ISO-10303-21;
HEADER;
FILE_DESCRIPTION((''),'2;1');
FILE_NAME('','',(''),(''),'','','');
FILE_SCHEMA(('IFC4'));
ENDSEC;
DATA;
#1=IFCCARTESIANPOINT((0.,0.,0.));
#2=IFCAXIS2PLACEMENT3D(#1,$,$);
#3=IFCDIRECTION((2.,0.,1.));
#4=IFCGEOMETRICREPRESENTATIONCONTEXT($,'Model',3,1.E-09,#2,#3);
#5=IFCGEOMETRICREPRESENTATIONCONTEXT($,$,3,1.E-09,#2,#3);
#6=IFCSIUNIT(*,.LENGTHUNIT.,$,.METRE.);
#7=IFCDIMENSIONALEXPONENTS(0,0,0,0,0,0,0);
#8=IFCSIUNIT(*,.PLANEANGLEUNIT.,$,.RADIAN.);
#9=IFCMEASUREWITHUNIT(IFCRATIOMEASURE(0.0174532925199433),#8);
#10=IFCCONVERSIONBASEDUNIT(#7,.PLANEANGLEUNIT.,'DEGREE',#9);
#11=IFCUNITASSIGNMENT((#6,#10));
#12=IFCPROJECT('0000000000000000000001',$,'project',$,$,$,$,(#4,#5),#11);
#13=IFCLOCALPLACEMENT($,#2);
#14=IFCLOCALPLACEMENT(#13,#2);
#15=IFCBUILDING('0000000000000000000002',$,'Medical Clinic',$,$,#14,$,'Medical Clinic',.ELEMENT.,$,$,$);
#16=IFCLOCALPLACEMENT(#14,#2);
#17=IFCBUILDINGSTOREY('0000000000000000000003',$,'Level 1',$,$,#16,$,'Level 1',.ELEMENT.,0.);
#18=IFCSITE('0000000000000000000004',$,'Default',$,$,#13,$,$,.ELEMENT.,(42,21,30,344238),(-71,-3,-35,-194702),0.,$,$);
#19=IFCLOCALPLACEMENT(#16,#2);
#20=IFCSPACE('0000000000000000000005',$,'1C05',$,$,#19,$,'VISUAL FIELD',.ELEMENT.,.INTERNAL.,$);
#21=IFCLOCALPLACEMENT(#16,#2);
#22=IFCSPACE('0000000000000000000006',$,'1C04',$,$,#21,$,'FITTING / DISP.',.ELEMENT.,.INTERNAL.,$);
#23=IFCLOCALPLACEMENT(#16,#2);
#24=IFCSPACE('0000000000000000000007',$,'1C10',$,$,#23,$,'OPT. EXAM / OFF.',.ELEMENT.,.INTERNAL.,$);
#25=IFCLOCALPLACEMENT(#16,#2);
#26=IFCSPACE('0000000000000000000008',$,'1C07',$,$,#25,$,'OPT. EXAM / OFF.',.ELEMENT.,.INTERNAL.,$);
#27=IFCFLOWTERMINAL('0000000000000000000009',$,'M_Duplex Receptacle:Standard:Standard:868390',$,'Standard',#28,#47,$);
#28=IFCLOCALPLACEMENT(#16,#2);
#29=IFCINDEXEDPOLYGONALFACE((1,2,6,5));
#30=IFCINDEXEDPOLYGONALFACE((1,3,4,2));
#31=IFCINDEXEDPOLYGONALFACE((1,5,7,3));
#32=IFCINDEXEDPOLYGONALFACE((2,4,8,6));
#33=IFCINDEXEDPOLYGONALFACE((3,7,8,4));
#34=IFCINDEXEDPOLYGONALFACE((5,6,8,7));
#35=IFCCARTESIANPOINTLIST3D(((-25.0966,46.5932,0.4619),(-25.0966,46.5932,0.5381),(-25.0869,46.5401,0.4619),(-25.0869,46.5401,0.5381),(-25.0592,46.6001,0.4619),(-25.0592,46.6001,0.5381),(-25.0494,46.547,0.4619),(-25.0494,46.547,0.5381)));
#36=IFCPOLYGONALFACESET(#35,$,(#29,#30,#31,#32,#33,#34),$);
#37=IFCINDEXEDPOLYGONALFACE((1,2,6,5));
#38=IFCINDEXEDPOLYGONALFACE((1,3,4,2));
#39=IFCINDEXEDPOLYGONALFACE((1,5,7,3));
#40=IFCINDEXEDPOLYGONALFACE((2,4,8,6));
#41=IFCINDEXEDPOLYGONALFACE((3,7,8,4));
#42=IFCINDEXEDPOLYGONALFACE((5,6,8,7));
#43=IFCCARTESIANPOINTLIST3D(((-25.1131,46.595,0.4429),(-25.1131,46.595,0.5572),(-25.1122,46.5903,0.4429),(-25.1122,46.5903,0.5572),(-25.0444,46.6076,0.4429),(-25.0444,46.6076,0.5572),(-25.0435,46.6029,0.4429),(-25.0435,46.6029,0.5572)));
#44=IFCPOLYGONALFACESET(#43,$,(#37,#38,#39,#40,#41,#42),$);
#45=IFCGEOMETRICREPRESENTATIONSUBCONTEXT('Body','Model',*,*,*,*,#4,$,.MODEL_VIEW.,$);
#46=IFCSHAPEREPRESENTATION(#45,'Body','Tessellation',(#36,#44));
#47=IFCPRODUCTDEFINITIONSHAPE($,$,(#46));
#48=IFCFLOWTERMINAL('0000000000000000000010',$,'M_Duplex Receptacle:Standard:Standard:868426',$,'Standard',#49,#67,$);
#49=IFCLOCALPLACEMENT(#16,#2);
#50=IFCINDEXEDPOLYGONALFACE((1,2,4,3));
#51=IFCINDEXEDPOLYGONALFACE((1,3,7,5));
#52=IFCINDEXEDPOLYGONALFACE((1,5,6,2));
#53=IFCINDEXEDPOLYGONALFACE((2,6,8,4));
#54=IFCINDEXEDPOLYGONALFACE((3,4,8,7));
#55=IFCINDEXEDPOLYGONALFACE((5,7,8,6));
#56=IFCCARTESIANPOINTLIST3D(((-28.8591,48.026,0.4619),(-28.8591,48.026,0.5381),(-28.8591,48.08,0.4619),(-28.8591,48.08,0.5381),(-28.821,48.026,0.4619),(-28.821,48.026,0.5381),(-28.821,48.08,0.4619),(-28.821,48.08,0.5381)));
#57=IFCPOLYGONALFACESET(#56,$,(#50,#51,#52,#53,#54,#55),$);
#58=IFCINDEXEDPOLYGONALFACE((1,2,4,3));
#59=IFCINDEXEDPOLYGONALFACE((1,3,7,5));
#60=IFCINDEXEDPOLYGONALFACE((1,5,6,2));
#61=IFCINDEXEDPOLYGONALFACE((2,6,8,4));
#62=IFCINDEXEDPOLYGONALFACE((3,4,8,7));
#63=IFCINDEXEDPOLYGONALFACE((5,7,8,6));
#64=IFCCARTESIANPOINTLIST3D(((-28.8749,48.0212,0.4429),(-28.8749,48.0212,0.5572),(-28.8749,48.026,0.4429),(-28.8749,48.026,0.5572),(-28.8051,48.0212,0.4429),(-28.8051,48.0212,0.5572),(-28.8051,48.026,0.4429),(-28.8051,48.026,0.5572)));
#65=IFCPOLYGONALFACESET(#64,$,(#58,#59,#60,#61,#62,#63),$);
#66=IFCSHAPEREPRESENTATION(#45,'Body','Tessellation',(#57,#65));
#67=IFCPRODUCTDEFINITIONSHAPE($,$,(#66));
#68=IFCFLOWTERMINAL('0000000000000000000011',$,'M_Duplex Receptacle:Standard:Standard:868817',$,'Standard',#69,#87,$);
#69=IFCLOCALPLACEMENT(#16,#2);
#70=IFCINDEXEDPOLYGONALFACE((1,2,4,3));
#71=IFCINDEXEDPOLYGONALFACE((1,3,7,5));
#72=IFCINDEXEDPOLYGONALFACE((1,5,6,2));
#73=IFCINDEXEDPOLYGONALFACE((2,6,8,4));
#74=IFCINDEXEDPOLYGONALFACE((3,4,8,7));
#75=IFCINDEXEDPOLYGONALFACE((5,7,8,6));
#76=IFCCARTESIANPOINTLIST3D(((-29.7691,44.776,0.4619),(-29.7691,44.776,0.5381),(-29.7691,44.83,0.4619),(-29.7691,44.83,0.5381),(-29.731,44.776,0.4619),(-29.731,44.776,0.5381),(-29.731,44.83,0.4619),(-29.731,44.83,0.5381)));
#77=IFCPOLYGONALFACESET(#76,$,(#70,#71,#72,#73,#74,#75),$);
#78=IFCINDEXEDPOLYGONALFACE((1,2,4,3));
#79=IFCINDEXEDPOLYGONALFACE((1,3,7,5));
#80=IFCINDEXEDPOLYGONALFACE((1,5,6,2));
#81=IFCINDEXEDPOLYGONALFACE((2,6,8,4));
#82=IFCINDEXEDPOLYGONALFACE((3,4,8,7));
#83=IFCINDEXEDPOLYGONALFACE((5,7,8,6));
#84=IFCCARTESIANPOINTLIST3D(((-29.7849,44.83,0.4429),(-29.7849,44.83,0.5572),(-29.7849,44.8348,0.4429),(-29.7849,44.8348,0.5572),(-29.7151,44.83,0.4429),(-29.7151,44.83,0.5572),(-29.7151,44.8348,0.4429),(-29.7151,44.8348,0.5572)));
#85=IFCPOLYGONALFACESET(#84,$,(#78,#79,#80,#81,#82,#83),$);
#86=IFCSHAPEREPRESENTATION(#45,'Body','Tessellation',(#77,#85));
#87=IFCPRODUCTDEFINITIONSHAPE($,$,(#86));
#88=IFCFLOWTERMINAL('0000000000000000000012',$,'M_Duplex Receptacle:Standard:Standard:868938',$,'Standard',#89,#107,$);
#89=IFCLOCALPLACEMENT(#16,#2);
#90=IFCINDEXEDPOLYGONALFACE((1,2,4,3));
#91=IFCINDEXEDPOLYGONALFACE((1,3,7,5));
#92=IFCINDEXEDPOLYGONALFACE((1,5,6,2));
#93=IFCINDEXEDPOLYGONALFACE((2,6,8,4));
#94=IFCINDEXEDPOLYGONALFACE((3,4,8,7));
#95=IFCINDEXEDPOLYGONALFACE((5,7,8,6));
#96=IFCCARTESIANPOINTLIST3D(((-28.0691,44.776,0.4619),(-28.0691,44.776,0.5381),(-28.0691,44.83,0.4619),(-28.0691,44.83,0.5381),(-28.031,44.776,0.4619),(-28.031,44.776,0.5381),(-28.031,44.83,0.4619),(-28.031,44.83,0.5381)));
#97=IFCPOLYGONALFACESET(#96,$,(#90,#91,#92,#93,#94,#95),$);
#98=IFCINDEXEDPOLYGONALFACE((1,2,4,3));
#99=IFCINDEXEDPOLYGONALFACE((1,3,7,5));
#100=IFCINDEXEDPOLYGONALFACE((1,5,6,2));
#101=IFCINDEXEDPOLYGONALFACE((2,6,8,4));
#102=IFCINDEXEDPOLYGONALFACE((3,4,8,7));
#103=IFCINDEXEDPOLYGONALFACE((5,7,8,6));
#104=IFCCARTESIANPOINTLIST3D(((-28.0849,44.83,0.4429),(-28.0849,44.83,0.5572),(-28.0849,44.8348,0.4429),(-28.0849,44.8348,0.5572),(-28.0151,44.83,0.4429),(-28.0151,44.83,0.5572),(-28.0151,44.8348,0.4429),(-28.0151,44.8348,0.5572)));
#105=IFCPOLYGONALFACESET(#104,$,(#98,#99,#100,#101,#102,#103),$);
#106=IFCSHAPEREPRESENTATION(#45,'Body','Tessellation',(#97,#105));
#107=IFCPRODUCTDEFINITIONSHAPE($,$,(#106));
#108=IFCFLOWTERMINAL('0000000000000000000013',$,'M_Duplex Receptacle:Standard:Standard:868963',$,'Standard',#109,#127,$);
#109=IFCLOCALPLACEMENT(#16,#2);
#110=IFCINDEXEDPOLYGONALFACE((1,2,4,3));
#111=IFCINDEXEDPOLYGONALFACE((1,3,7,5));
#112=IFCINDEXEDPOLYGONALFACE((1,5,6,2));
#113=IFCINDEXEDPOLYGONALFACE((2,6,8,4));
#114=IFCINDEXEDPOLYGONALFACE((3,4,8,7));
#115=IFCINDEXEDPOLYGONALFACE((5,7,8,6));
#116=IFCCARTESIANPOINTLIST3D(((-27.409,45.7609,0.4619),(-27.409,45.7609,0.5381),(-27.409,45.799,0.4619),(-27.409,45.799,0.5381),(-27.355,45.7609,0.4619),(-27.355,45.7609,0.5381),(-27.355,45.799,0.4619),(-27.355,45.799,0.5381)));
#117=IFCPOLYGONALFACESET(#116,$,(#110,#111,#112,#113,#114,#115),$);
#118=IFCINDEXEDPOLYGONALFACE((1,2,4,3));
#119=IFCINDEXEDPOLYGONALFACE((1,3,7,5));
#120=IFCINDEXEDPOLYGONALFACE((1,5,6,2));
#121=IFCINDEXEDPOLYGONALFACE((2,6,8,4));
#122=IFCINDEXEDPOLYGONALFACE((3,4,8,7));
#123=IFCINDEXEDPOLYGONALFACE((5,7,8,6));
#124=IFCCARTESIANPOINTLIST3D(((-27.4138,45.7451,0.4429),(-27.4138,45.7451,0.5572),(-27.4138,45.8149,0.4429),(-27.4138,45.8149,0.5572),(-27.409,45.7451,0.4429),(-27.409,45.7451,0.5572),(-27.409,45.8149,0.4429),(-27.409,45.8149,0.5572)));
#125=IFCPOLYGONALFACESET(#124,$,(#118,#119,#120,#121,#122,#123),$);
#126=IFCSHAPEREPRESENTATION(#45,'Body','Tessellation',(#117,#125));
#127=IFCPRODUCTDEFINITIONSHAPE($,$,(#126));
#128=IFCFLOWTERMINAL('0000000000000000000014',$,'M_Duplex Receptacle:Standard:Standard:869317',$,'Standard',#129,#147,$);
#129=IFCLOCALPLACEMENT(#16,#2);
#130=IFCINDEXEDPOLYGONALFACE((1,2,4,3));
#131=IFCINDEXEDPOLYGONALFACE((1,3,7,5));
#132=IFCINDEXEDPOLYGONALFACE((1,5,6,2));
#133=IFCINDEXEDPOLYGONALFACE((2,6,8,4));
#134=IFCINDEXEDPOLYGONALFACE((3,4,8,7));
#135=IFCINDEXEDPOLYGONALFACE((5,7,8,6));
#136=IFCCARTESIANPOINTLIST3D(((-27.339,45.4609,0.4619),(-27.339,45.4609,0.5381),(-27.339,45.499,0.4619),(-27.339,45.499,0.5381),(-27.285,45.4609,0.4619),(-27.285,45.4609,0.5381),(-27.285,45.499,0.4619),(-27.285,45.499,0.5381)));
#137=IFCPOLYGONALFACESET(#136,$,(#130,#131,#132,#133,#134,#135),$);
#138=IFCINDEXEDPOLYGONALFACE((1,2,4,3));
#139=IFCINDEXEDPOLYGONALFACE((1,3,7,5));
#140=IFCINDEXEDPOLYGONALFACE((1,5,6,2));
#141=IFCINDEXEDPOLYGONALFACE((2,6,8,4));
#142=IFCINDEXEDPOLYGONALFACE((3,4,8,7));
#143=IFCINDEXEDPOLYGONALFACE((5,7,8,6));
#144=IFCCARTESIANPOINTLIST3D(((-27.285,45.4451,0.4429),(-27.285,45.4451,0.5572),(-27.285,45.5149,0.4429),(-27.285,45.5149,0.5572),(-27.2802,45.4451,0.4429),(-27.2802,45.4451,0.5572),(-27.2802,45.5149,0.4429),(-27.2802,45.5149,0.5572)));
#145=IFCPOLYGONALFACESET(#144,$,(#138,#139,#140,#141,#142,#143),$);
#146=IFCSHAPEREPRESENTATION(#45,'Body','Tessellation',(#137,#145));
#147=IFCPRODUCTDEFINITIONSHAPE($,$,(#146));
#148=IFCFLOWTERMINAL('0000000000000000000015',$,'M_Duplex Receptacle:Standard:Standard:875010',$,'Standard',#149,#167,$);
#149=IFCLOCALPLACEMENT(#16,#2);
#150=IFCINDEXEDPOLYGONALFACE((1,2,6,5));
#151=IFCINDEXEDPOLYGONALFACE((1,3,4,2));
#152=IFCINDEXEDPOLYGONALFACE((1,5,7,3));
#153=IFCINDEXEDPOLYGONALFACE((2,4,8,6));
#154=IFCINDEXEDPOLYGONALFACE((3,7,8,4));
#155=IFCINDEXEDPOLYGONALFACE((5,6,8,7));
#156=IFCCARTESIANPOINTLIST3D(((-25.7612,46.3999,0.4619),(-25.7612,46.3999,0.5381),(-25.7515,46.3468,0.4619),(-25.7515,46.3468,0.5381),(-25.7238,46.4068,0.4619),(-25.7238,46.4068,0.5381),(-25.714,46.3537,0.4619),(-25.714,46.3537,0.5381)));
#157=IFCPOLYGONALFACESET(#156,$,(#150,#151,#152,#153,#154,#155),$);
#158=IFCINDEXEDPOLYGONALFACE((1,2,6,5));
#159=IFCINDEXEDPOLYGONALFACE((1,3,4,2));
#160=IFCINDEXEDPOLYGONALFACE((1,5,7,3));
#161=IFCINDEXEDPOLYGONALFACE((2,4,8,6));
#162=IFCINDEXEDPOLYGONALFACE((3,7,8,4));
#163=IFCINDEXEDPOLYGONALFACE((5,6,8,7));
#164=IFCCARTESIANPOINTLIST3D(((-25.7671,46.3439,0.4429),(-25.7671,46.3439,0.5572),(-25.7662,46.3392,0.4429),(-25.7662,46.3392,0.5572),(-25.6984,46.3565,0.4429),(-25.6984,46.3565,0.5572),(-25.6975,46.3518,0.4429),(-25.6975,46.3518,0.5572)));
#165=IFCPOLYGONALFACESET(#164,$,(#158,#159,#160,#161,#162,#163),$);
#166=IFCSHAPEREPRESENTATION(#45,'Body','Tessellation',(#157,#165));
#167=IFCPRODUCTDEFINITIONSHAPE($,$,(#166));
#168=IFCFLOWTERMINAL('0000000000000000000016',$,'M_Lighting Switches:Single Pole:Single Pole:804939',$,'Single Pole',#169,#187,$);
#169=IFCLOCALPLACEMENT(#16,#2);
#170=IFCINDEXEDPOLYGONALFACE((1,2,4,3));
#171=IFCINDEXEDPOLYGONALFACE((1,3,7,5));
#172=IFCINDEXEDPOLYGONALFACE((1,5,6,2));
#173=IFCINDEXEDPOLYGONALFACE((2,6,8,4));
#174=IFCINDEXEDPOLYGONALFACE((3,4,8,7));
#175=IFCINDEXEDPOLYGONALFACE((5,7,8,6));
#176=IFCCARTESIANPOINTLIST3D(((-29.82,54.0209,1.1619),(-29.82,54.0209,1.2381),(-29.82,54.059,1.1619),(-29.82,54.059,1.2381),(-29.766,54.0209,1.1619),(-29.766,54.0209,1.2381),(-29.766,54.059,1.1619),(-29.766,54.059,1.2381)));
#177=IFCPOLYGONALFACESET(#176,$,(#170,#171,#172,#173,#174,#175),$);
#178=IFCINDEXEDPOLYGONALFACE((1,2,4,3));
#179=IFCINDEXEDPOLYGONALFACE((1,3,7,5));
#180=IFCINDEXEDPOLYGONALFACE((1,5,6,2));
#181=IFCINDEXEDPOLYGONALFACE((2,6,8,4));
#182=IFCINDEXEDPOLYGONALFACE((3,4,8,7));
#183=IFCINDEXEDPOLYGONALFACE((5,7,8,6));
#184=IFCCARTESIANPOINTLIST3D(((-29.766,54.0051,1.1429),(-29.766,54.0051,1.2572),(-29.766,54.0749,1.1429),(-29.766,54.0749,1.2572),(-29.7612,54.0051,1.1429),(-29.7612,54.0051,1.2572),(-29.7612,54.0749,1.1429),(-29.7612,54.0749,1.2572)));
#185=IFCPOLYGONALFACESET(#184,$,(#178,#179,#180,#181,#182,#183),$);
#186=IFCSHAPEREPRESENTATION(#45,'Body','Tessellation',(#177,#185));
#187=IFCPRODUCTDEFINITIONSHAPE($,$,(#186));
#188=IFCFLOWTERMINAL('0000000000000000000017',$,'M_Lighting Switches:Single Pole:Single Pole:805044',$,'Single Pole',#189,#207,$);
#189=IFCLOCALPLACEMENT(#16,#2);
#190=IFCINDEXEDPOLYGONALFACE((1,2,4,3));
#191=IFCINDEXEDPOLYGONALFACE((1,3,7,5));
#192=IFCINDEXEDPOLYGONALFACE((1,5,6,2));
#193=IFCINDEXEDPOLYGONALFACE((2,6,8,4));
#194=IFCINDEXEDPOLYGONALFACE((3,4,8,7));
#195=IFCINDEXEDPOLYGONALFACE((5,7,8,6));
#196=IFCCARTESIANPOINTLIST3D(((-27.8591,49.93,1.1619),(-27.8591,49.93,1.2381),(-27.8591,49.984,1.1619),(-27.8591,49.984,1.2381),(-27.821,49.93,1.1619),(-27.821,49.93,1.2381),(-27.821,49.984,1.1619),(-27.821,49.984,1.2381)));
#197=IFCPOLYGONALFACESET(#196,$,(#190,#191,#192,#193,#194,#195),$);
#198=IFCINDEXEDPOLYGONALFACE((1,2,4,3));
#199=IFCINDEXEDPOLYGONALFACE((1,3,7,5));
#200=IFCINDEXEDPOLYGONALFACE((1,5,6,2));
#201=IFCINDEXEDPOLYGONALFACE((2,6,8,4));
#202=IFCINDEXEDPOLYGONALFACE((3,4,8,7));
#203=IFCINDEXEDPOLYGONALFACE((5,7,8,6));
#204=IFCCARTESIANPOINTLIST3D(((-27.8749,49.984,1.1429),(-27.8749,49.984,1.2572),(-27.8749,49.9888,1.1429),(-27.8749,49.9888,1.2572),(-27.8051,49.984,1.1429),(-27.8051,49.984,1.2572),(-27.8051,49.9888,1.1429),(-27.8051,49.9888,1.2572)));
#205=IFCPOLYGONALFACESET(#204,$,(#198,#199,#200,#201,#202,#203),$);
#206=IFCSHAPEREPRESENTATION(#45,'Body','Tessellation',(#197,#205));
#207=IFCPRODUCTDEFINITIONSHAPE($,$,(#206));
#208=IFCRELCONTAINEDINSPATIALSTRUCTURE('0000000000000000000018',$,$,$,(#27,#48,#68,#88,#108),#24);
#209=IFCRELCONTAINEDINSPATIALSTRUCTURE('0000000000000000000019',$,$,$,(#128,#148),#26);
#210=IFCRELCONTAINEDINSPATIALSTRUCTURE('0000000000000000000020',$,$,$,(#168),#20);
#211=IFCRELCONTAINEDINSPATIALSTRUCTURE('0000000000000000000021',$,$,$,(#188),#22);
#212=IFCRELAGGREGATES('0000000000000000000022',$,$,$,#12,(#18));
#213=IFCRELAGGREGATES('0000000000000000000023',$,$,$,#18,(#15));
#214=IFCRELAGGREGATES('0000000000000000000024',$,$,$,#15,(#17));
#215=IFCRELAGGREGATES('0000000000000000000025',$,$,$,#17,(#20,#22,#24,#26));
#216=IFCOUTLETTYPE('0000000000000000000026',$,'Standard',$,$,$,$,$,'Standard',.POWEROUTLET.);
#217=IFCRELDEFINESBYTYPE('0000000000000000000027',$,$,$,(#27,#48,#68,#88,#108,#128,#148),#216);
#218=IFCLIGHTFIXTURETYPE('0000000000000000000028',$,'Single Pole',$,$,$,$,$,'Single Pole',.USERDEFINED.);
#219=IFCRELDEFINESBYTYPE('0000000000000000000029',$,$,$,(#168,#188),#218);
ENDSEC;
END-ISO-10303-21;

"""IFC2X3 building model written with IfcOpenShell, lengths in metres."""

from ifc_helpers import new_model, entity, si_unit, converted_unit, direction, frame, frame_2d, origin, origin_2d_with_axis, place, context, subcontext, project, spatial, rectangle, extrude, source, transform, mapped, type_object, type_shapes, element, save


model = new_model("IFC2X3")

# Units and contexts
model_context = context("Model", 3, precision=1e-09, world=origin(), true_north=direction((2.0, 0.0, 1.0)))
context_of_model = context(None, 3, precision=1e-09, world=origin(), true_north=direction((2.0, 0.0, 1.0)))
body_context = subcontext(model_context, "Body", "Model", "MODEL_VIEW")
ifc_project = project(units=[si_unit("LENGTHUNIT", "METRE"), converted_unit("PLANEANGLEUNIT", "DEGREE", entity("IfcRatioMeasure", 0.0174532925199433), si_unit("PLANEANGLEUNIT", "RADIAN"), dimensions=[0, 0, 0, 0, 0, 0, 0])], contexts=[model_context, context_of_model])

# Site, building, storey, space
site_placement = place(None, origin())
site = spatial("IfcSite", under=ifc_project, at=site_placement, Name="Default", CompositionType="ELEMENT", RefLatitude=(42, 21, 30, 344238), RefLongitude=(-71, -3, -35, -194702), RefElevation=0.0)
building_placement = place(site_placement, origin())
building = spatial("IfcBuilding", under=site, at=building_placement, Name="Medical Clinic", LongName="Medical Clinic", CompositionType="ELEMENT")
storey_placement = place(building_placement, origin())
storey = spatial("IfcBuildingStorey", under=building, at=storey_placement, Name="Level 1", LongName="Level 1", CompositionType="ELEMENT", Elevation=0.0)
space_1_placement = place(storey_placement, origin())
space_1 = spatial("IfcSpace", under=storey, at=space_1_placement, Name="1C05", LongName="VISUAL FIELD", CompositionType="ELEMENT", InteriorOrExteriorSpace="INTERNAL")

# Shared definitions
outlet_type = type_object("IfcOutletType", Name="Standard", ElementType="Standard", PredefinedType="POWEROUTLET")
shared_shape_1 = source(origin(), body_context, "Body", "SweptSolid", [
    extrude(rectangle(XDim=0.0381, YDim=0.0762, at=origin_2d_with_axis()), frame((0.0, 0.0, -0.054), z_axis=(0.0, 0.0, 1.0), x_axis=(-1.0, 0.0, 0.0)), (0.0, 0.0, 1.0), 0.054),
    extrude(rectangle(XDim=0.0698, YDim=0.1143, at=frame_2d((0.0, 0.0), x_axis=(1.0, 0.0))), frame((0.0, 0.0, 0.0), z_axis=(0.0, 0.0, 1.0), x_axis=(-1.0, 0.0, 0.0)), (0.0, 0.0, 1.0), 0.0048),
])
type_shapes(outlet_type, [shared_shape_1])

# Shared definitions
space_2_placement = place(storey_placement, origin())
space_2 = spatial("IfcSpace", under=storey, at=space_2_placement, Name="1C04", LongName="FITTING / DISP.", CompositionType="ELEMENT", InteriorOrExteriorSpace="INTERNAL")

# Shared definitions
space_3_placement = place(storey_placement, origin())
space_3 = spatial("IfcSpace", under=storey, at=space_3_placement, Name="1C10", LongName="OPT. EXAM / OFF.", CompositionType="ELEMENT", InteriorOrExteriorSpace="INTERNAL")

# Flow terminals
for number, where, z_axis, x_axis, name in (
    (1, (-25.0779, 46.5966, 0.5), (-0.180702, 0.983538, 0.0), (-0.983538, -0.180702, 0.0), "M_Duplex Receptacle:Standard:Standard:868390"),
    (2, (-28.84, 48.026, 0.5), (0.0, -1.0, 0.0), (1.0, 0.0, 0.0), "M_Duplex Receptacle:Standard:Standard:868426"),
    (3, (-29.75, 44.83, 0.5), (0.0, 1.0, 0.0), (-1.0, 0.0, 0.0), "M_Duplex Receptacle:Standard:Standard:868817"),
    (4, (-28.05, 44.83, 0.5), (0.0, 1.0, 0.0), (-1.0, 0.0, 0.0), "M_Duplex Receptacle:Standard:Standard:868938"),
    (5, (-27.409, 45.78, 0.5), (-1.0, 0.0, 0.0), (0.0, -1.0, 0.0), "M_Duplex Receptacle:Standard:Standard:868963"),
):
    element("IfcFlowTerminal", number, at=place(space_3_placement, frame(where, z_axis=z_axis, x_axis=x_axis)), inside=space_3, type_object=outlet_type, Name=name, ObjectType="Standard", context=body_context, shape_type="MappedRepresentation", body=[
        mapped(shared_shape_1, transform((0.0, 0.0, 0.0), scale=1.0)),
    ])

# Shared definitions
space_4_placement = place(storey_placement, origin())
space_4 = spatial("IfcSpace", under=storey, at=space_4_placement, Name="1C07", LongName="OPT. EXAM / OFF.", CompositionType="ELEMENT", InteriorOrExteriorSpace="INTERNAL")

# Flow terminals
for number, where, z_axis, x_axis, name in (
    (6, (-27.285, 45.48, 0.5), (1.0, 0.0, 0.0), (0.0, 1.0, 0.0), "M_Duplex Receptacle:Standard:Standard:869317"),
    (7, (-25.7327, 46.3502, 0.5), (0.180702, -0.983538, 0.0), (0.983538, 0.180702, 0.0), "M_Duplex Receptacle:Standard:Standard:875010"),
):
    element("IfcFlowTerminal", number, at=place(space_4_placement, frame(where, z_axis=z_axis, x_axis=x_axis)), inside=space_4, type_object=outlet_type, Name=name, ObjectType="Standard", context=body_context, shape_type="MappedRepresentation", body=[
        mapped(shared_shape_1, transform((0.0, 0.0, 0.0), scale=1.0)),
    ])
light_fixture_type_1 = type_object("IfcLightFixtureType", Name="Single Pole", ElementType="Single Pole", PredefinedType="USERDEFINED")
shared_shape_2 = source(origin(), body_context, "Body", "SweptSolid", [
    extrude(rectangle(XDim=0.0381, YDim=0.0762, at=origin_2d_with_axis()), frame((0.0, 0.0, -0.054), z_axis=(0.0, 0.0, 1.0), x_axis=(-1.0, 0.0, 0.0)), (0.0, 0.0, 1.0), 0.054),
    extrude(rectangle(XDim=0.0698, YDim=0.1143, at=frame_2d((0.0, 0.0), x_axis=(1.0, 0.0))), frame((0.0, 0.0, 0.0), z_axis=(0.0, 0.0, 1.0), x_axis=(-1.0, 0.0, 0.0)), (0.0, 0.0, 1.0), 0.0048),
])
type_shapes(light_fixture_type_1, [shared_shape_2])
flow_terminal_1_placement = place(space_1_placement, frame((-29.766, 54.04, 1.2), z_axis=(1.0, 0.0, 0.0), x_axis=(0.0, 1.0, 0.0)))
element("IfcFlowTerminal", 8, at=flow_terminal_1_placement, inside=space_1, type_object=light_fixture_type_1, Name="M_Lighting Switches:Single Pole:Single Pole:804939", ObjectType="Single Pole", context=body_context, shape_type="MappedRepresentation", body=[
    mapped(shared_shape_2, transform((0.0, 0.0, 0.0), scale=1.0)),
])
flow_terminal_2_placement = place(space_2_placement, frame((-27.84, 49.984, 1.2), z_axis=(0.0, 1.0, 0.0), x_axis=(-1.0, 0.0, 0.0)))
element("IfcFlowTerminal", 9, at=flow_terminal_2_placement, inside=space_2, type_object=light_fixture_type_1, Name="M_Lighting Switches:Single Pole:Single Pole:805044", ObjectType="Single Pole", context=body_context, shape_type="MappedRepresentation", body=[
    mapped(shared_shape_2, transform((0.0, 0.0, 0.0), scale=1.0)),
])

save(model, "model.ifc")
